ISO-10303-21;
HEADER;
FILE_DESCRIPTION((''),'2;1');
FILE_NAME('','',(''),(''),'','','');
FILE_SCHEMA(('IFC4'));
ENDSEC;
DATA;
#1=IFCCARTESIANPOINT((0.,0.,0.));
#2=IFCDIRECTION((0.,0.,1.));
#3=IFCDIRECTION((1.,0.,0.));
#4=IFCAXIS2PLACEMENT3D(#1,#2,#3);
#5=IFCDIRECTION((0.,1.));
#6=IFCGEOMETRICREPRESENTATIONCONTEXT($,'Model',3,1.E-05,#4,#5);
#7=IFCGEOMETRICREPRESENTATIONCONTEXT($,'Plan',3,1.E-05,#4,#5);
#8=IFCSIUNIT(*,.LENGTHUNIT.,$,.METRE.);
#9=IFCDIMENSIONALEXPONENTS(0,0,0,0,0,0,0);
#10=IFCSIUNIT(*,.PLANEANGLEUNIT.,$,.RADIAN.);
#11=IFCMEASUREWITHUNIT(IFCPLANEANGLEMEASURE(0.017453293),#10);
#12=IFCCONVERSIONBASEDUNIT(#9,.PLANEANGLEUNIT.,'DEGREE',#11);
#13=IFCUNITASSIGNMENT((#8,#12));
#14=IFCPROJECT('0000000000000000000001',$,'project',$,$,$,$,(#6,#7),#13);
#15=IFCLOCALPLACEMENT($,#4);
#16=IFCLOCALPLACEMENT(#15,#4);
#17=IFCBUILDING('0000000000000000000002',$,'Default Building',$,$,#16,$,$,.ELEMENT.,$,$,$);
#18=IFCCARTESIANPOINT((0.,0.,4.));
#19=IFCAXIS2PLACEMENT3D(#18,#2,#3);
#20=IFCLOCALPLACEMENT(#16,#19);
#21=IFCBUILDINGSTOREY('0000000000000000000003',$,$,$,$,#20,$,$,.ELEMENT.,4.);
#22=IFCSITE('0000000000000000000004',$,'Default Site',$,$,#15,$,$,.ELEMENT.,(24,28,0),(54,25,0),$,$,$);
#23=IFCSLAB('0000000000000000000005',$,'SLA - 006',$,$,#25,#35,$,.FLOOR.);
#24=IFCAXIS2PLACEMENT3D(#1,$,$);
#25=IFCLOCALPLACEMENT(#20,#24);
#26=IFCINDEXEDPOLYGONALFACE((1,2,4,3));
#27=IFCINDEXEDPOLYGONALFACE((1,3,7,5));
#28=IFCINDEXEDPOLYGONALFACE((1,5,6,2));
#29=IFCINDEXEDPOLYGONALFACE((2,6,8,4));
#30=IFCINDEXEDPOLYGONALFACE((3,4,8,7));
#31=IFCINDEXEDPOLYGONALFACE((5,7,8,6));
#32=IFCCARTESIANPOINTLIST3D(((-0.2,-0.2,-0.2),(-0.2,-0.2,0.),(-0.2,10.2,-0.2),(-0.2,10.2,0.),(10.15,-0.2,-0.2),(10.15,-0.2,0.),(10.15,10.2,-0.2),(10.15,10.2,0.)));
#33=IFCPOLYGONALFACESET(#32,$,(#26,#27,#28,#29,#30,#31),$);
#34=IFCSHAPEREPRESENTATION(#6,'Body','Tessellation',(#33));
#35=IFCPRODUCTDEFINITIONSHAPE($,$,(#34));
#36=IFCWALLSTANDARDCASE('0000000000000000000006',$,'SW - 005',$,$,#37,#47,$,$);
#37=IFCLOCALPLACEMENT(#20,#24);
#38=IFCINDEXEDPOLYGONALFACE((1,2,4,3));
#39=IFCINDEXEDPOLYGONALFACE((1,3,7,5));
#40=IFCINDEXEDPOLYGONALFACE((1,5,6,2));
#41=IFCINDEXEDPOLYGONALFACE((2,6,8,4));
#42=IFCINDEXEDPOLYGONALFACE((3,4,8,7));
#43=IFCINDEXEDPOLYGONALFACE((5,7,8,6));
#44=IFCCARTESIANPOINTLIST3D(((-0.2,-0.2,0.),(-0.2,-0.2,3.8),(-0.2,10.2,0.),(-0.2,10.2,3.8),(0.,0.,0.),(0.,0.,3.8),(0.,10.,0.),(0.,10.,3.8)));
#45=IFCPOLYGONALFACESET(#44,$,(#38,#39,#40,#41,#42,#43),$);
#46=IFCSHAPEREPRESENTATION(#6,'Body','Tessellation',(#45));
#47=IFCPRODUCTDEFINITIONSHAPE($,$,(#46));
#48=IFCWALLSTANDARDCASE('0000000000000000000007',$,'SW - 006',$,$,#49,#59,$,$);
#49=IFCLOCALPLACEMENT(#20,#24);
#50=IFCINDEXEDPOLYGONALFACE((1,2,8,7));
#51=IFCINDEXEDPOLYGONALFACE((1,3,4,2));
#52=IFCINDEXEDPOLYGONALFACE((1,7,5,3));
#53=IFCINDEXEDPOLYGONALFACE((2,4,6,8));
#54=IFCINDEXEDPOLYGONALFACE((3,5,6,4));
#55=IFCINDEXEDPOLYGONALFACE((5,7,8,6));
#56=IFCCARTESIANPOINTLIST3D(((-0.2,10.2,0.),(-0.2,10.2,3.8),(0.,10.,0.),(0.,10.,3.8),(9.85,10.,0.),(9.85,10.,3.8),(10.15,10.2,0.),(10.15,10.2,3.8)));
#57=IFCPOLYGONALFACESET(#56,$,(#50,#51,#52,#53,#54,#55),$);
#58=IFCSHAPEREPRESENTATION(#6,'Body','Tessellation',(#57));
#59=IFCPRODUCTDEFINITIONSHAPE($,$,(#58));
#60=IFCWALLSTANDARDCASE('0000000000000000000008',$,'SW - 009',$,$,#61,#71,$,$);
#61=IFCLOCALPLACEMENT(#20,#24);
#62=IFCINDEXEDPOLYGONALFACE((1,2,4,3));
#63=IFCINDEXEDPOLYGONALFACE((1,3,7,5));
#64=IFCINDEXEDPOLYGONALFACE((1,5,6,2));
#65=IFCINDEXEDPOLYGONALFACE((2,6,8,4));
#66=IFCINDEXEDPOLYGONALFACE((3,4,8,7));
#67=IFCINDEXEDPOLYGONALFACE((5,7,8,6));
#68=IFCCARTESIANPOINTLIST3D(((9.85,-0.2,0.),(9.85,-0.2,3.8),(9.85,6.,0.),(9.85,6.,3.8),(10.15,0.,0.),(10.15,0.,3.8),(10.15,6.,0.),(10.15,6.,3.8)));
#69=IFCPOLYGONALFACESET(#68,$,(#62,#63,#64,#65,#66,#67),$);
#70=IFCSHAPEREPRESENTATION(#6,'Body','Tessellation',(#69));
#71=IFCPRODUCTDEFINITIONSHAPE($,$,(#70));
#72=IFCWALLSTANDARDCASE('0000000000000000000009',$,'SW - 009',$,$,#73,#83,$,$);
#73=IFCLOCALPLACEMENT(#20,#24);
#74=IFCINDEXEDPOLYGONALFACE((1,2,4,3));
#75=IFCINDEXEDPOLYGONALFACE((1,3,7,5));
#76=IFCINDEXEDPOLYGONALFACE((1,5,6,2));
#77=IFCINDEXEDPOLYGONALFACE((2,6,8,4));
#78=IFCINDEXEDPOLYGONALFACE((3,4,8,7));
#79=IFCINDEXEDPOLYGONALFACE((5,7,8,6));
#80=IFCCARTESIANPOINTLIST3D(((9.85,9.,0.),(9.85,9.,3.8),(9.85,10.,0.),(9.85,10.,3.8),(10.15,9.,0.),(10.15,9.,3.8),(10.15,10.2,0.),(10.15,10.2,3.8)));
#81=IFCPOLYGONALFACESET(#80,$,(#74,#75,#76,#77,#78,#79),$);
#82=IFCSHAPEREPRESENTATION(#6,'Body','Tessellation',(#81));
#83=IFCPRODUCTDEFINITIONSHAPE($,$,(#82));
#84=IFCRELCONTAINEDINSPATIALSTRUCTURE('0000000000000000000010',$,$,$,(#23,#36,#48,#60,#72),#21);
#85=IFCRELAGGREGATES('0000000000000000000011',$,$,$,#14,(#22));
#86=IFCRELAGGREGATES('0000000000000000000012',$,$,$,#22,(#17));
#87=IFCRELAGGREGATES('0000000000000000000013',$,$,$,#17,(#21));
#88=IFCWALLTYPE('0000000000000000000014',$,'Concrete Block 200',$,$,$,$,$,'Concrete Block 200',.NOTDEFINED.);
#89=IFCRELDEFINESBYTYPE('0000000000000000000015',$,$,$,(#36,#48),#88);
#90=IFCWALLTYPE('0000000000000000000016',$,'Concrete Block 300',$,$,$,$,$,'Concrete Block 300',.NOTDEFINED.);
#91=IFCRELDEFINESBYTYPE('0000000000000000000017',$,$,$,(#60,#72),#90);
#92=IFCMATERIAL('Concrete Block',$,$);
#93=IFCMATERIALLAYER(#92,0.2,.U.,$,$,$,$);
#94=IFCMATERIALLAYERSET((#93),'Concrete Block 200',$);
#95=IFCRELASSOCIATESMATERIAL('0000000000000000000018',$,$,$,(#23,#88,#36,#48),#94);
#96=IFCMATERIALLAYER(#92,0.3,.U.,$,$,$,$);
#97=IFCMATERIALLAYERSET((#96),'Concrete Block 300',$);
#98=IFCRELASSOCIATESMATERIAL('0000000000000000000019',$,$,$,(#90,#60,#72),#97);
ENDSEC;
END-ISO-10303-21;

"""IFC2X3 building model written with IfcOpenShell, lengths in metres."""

from ifc_helpers import new_model, entity, si_unit, converted_unit, direction, frame, origin_with_axes, place, context, project, spatial, polyline, outline, extrude, material, layer, layer_set, layer_usage, type_object, element, save


model = new_model("IFC2X3")

# Units and contexts
model_context = context("Model", 3, precision=1e-05, world=origin_with_axes(), true_north=direction((0.0, 1.0)))
plan_context = context("Plan", 3, precision=1e-05, world=origin_with_axes(), true_north=direction((0.0, 1.0)))
ifc_project = project(units=[si_unit("LENGTHUNIT", "METRE"), converted_unit("PLANEANGLEUNIT", "DEGREE", entity("IfcPlaneAngleMeasure", 0.017453293), si_unit("PLANEANGLEUNIT", "RADIAN"), dimensions=[0, 0, 0, 0, 0, 0, 0])], contexts=[model_context, plan_context])

# Site, building, storey
site_placement = place(None, origin_with_axes())
site = spatial("IfcSite", under=ifc_project, at=site_placement, Name="Default Site", CompositionType="ELEMENT", RefLatitude=(24, 28, 0), RefLongitude=(54, 25, 0))
building_placement = place(site_placement, origin_with_axes())
building = spatial("IfcBuilding", under=site, at=building_placement, Name="Default Building", CompositionType="ELEMENT")
storey_placement = place(building_placement, frame((0.0, 0.0, 4.0), z_axis=(0.0, 0.0, 1.0), x_axis=(1.0, 0.0, 0.0)))
storey = spatial("IfcBuildingStorey", under=building, at=storey_placement, CompositionType="ELEMENT", Elevation=4.0)

# Slab
ifc_material = material(Name="Concrete Block")
ifc_layer_1 = layer(ifc_material, 0.2, ventilated="UNKNOWN")
ifc_layer_set_1 = layer_set([ifc_layer_1], Name="Concrete Block 200")
ifc_layer_usage_1 = layer_usage(ifc_layer_set_1, "AXIS3", "NEGATIVE", 0.2)
slab_placement = place(storey_placement, frame((-0.2, 10.2, -0.2), z_axis=(0.0, 0.0, 1.0), x_axis=(0.0, -1.0, 0.0)))
element("IfcSlab", 1, at=slab_placement, inside=storey, material=ifc_layer_usage_1, Name="SLA - 006", PredefinedType="FLOOR", context=model_context, shape_type="SweptSolid", body=[
    extrude(outline(polyline([(0.0, 0.0), (10.4, 0.0), (10.4, 10.35), (0.0, 10.35), (0.0, 0.0)])), origin_with_axes(), (0.0, 0.0, 1.0), 0.2),
])

# Walls
ifc_layer_usage_2 = layer_usage(ifc_layer_set_1, "AXIS2", "POSITIVE", 0.0)
wall_type_1 = type_object("IfcWallType", Name="Concrete Block 200", ElementType="Concrete Block 200", PredefinedType="NOTDEFINED", material=ifc_layer_set_1)
wall_1_placement = place(storey_placement, frame((0.0, 0.0, 0.0), z_axis=(0.0, 0.0, 1.0), x_axis=(0.0, 1.0, 0.0)))
element("IfcWallStandardCase", 2, at=wall_1_placement, inside=storey, type_object=wall_type_1, material=ifc_layer_usage_2, Name="SW - 005", context=model_context, shape_type="SweptSolid", body=[
    extrude(outline(polyline([(0.0, 0.0), (10.0, 0.0), (10.2, 0.2), (-0.2, 0.2), (0.0, 0.0)])), origin_with_axes(), (0.0, 0.0, 1.0), 3.8),
])
ifc_layer_usage_3 = layer_usage(ifc_layer_set_1, "AXIS2", "POSITIVE", 0.0)
wall_2_placement = place(storey_placement, frame((0.0, 10.0, 0.0), z_axis=(0.0, 0.0, 1.0), x_axis=(1.0, 0.0, 0.0)))
element("IfcWallStandardCase", 3, at=wall_2_placement, inside=storey, type_object=wall_type_1, material=ifc_layer_usage_3, Name="SW - 006", context=model_context, shape_type="SweptSolid", body=[
    extrude(outline(polyline([(0.0, 0.0), (9.85, 0.0), (10.15, 0.2), (-0.2, 0.2), (0.0, 0.0)])), origin_with_axes(), (0.0, 0.0, 1.0), 3.8),
])
ifc_layer_2 = layer(ifc_material, 0.3, ventilated="UNKNOWN")
ifc_layer_set_2 = layer_set([ifc_layer_2], Name="Concrete Block 300")
ifc_layer_usage_4 = layer_usage(ifc_layer_set_2, "AXIS2", "POSITIVE", 0.0)
wall_type_2 = type_object("IfcWallType", Name="Concrete Block 300", ElementType="Concrete Block 300", PredefinedType="NOTDEFINED", material=ifc_layer_set_2)
wall_3_placement = place(storey_placement, frame((10.15, 0.0, 0.0), z_axis=(0.0, 0.0, 1.0), x_axis=(0.0, 1.0, 0.0)))
element("IfcWallStandardCase", 4, at=wall_3_placement, inside=storey, type_object=wall_type_2, material=ifc_layer_usage_4, Name="SW - 009", context=model_context, shape_type="SweptSolid", body=[
    extrude(outline(polyline([(0.0, 0.0), (6.0, 0.0), (6.0, 0.3), (-0.2, 0.3), (0.0, 0.0)])), origin_with_axes(), (0.0, 0.0, 1.0), 3.8),
])
ifc_layer_usage_5 = layer_usage(ifc_layer_set_2, "AXIS2", "POSITIVE", 0.0)
wall_4_placement = place(storey_placement, frame((10.15, 9.0, 0.0), z_axis=(0.0, 0.0, 1.0), x_axis=(0.0, 1.0, 0.0)))
element("IfcWallStandardCase", 5, at=wall_4_placement, inside=storey, type_object=wall_type_2, material=ifc_layer_usage_5, Name="SW - 009", context=model_context, shape_type="SweptSolid", body=[
    extrude(outline(polyline([(0.0, 0.0), (1.2, 0.0), (1.0, 0.3), (0.0, 0.3), (0.0, 0.0)])), origin_with_axes(), (0.0, 0.0, 1.0), 3.8),
])

save(model, "model.ifc")
